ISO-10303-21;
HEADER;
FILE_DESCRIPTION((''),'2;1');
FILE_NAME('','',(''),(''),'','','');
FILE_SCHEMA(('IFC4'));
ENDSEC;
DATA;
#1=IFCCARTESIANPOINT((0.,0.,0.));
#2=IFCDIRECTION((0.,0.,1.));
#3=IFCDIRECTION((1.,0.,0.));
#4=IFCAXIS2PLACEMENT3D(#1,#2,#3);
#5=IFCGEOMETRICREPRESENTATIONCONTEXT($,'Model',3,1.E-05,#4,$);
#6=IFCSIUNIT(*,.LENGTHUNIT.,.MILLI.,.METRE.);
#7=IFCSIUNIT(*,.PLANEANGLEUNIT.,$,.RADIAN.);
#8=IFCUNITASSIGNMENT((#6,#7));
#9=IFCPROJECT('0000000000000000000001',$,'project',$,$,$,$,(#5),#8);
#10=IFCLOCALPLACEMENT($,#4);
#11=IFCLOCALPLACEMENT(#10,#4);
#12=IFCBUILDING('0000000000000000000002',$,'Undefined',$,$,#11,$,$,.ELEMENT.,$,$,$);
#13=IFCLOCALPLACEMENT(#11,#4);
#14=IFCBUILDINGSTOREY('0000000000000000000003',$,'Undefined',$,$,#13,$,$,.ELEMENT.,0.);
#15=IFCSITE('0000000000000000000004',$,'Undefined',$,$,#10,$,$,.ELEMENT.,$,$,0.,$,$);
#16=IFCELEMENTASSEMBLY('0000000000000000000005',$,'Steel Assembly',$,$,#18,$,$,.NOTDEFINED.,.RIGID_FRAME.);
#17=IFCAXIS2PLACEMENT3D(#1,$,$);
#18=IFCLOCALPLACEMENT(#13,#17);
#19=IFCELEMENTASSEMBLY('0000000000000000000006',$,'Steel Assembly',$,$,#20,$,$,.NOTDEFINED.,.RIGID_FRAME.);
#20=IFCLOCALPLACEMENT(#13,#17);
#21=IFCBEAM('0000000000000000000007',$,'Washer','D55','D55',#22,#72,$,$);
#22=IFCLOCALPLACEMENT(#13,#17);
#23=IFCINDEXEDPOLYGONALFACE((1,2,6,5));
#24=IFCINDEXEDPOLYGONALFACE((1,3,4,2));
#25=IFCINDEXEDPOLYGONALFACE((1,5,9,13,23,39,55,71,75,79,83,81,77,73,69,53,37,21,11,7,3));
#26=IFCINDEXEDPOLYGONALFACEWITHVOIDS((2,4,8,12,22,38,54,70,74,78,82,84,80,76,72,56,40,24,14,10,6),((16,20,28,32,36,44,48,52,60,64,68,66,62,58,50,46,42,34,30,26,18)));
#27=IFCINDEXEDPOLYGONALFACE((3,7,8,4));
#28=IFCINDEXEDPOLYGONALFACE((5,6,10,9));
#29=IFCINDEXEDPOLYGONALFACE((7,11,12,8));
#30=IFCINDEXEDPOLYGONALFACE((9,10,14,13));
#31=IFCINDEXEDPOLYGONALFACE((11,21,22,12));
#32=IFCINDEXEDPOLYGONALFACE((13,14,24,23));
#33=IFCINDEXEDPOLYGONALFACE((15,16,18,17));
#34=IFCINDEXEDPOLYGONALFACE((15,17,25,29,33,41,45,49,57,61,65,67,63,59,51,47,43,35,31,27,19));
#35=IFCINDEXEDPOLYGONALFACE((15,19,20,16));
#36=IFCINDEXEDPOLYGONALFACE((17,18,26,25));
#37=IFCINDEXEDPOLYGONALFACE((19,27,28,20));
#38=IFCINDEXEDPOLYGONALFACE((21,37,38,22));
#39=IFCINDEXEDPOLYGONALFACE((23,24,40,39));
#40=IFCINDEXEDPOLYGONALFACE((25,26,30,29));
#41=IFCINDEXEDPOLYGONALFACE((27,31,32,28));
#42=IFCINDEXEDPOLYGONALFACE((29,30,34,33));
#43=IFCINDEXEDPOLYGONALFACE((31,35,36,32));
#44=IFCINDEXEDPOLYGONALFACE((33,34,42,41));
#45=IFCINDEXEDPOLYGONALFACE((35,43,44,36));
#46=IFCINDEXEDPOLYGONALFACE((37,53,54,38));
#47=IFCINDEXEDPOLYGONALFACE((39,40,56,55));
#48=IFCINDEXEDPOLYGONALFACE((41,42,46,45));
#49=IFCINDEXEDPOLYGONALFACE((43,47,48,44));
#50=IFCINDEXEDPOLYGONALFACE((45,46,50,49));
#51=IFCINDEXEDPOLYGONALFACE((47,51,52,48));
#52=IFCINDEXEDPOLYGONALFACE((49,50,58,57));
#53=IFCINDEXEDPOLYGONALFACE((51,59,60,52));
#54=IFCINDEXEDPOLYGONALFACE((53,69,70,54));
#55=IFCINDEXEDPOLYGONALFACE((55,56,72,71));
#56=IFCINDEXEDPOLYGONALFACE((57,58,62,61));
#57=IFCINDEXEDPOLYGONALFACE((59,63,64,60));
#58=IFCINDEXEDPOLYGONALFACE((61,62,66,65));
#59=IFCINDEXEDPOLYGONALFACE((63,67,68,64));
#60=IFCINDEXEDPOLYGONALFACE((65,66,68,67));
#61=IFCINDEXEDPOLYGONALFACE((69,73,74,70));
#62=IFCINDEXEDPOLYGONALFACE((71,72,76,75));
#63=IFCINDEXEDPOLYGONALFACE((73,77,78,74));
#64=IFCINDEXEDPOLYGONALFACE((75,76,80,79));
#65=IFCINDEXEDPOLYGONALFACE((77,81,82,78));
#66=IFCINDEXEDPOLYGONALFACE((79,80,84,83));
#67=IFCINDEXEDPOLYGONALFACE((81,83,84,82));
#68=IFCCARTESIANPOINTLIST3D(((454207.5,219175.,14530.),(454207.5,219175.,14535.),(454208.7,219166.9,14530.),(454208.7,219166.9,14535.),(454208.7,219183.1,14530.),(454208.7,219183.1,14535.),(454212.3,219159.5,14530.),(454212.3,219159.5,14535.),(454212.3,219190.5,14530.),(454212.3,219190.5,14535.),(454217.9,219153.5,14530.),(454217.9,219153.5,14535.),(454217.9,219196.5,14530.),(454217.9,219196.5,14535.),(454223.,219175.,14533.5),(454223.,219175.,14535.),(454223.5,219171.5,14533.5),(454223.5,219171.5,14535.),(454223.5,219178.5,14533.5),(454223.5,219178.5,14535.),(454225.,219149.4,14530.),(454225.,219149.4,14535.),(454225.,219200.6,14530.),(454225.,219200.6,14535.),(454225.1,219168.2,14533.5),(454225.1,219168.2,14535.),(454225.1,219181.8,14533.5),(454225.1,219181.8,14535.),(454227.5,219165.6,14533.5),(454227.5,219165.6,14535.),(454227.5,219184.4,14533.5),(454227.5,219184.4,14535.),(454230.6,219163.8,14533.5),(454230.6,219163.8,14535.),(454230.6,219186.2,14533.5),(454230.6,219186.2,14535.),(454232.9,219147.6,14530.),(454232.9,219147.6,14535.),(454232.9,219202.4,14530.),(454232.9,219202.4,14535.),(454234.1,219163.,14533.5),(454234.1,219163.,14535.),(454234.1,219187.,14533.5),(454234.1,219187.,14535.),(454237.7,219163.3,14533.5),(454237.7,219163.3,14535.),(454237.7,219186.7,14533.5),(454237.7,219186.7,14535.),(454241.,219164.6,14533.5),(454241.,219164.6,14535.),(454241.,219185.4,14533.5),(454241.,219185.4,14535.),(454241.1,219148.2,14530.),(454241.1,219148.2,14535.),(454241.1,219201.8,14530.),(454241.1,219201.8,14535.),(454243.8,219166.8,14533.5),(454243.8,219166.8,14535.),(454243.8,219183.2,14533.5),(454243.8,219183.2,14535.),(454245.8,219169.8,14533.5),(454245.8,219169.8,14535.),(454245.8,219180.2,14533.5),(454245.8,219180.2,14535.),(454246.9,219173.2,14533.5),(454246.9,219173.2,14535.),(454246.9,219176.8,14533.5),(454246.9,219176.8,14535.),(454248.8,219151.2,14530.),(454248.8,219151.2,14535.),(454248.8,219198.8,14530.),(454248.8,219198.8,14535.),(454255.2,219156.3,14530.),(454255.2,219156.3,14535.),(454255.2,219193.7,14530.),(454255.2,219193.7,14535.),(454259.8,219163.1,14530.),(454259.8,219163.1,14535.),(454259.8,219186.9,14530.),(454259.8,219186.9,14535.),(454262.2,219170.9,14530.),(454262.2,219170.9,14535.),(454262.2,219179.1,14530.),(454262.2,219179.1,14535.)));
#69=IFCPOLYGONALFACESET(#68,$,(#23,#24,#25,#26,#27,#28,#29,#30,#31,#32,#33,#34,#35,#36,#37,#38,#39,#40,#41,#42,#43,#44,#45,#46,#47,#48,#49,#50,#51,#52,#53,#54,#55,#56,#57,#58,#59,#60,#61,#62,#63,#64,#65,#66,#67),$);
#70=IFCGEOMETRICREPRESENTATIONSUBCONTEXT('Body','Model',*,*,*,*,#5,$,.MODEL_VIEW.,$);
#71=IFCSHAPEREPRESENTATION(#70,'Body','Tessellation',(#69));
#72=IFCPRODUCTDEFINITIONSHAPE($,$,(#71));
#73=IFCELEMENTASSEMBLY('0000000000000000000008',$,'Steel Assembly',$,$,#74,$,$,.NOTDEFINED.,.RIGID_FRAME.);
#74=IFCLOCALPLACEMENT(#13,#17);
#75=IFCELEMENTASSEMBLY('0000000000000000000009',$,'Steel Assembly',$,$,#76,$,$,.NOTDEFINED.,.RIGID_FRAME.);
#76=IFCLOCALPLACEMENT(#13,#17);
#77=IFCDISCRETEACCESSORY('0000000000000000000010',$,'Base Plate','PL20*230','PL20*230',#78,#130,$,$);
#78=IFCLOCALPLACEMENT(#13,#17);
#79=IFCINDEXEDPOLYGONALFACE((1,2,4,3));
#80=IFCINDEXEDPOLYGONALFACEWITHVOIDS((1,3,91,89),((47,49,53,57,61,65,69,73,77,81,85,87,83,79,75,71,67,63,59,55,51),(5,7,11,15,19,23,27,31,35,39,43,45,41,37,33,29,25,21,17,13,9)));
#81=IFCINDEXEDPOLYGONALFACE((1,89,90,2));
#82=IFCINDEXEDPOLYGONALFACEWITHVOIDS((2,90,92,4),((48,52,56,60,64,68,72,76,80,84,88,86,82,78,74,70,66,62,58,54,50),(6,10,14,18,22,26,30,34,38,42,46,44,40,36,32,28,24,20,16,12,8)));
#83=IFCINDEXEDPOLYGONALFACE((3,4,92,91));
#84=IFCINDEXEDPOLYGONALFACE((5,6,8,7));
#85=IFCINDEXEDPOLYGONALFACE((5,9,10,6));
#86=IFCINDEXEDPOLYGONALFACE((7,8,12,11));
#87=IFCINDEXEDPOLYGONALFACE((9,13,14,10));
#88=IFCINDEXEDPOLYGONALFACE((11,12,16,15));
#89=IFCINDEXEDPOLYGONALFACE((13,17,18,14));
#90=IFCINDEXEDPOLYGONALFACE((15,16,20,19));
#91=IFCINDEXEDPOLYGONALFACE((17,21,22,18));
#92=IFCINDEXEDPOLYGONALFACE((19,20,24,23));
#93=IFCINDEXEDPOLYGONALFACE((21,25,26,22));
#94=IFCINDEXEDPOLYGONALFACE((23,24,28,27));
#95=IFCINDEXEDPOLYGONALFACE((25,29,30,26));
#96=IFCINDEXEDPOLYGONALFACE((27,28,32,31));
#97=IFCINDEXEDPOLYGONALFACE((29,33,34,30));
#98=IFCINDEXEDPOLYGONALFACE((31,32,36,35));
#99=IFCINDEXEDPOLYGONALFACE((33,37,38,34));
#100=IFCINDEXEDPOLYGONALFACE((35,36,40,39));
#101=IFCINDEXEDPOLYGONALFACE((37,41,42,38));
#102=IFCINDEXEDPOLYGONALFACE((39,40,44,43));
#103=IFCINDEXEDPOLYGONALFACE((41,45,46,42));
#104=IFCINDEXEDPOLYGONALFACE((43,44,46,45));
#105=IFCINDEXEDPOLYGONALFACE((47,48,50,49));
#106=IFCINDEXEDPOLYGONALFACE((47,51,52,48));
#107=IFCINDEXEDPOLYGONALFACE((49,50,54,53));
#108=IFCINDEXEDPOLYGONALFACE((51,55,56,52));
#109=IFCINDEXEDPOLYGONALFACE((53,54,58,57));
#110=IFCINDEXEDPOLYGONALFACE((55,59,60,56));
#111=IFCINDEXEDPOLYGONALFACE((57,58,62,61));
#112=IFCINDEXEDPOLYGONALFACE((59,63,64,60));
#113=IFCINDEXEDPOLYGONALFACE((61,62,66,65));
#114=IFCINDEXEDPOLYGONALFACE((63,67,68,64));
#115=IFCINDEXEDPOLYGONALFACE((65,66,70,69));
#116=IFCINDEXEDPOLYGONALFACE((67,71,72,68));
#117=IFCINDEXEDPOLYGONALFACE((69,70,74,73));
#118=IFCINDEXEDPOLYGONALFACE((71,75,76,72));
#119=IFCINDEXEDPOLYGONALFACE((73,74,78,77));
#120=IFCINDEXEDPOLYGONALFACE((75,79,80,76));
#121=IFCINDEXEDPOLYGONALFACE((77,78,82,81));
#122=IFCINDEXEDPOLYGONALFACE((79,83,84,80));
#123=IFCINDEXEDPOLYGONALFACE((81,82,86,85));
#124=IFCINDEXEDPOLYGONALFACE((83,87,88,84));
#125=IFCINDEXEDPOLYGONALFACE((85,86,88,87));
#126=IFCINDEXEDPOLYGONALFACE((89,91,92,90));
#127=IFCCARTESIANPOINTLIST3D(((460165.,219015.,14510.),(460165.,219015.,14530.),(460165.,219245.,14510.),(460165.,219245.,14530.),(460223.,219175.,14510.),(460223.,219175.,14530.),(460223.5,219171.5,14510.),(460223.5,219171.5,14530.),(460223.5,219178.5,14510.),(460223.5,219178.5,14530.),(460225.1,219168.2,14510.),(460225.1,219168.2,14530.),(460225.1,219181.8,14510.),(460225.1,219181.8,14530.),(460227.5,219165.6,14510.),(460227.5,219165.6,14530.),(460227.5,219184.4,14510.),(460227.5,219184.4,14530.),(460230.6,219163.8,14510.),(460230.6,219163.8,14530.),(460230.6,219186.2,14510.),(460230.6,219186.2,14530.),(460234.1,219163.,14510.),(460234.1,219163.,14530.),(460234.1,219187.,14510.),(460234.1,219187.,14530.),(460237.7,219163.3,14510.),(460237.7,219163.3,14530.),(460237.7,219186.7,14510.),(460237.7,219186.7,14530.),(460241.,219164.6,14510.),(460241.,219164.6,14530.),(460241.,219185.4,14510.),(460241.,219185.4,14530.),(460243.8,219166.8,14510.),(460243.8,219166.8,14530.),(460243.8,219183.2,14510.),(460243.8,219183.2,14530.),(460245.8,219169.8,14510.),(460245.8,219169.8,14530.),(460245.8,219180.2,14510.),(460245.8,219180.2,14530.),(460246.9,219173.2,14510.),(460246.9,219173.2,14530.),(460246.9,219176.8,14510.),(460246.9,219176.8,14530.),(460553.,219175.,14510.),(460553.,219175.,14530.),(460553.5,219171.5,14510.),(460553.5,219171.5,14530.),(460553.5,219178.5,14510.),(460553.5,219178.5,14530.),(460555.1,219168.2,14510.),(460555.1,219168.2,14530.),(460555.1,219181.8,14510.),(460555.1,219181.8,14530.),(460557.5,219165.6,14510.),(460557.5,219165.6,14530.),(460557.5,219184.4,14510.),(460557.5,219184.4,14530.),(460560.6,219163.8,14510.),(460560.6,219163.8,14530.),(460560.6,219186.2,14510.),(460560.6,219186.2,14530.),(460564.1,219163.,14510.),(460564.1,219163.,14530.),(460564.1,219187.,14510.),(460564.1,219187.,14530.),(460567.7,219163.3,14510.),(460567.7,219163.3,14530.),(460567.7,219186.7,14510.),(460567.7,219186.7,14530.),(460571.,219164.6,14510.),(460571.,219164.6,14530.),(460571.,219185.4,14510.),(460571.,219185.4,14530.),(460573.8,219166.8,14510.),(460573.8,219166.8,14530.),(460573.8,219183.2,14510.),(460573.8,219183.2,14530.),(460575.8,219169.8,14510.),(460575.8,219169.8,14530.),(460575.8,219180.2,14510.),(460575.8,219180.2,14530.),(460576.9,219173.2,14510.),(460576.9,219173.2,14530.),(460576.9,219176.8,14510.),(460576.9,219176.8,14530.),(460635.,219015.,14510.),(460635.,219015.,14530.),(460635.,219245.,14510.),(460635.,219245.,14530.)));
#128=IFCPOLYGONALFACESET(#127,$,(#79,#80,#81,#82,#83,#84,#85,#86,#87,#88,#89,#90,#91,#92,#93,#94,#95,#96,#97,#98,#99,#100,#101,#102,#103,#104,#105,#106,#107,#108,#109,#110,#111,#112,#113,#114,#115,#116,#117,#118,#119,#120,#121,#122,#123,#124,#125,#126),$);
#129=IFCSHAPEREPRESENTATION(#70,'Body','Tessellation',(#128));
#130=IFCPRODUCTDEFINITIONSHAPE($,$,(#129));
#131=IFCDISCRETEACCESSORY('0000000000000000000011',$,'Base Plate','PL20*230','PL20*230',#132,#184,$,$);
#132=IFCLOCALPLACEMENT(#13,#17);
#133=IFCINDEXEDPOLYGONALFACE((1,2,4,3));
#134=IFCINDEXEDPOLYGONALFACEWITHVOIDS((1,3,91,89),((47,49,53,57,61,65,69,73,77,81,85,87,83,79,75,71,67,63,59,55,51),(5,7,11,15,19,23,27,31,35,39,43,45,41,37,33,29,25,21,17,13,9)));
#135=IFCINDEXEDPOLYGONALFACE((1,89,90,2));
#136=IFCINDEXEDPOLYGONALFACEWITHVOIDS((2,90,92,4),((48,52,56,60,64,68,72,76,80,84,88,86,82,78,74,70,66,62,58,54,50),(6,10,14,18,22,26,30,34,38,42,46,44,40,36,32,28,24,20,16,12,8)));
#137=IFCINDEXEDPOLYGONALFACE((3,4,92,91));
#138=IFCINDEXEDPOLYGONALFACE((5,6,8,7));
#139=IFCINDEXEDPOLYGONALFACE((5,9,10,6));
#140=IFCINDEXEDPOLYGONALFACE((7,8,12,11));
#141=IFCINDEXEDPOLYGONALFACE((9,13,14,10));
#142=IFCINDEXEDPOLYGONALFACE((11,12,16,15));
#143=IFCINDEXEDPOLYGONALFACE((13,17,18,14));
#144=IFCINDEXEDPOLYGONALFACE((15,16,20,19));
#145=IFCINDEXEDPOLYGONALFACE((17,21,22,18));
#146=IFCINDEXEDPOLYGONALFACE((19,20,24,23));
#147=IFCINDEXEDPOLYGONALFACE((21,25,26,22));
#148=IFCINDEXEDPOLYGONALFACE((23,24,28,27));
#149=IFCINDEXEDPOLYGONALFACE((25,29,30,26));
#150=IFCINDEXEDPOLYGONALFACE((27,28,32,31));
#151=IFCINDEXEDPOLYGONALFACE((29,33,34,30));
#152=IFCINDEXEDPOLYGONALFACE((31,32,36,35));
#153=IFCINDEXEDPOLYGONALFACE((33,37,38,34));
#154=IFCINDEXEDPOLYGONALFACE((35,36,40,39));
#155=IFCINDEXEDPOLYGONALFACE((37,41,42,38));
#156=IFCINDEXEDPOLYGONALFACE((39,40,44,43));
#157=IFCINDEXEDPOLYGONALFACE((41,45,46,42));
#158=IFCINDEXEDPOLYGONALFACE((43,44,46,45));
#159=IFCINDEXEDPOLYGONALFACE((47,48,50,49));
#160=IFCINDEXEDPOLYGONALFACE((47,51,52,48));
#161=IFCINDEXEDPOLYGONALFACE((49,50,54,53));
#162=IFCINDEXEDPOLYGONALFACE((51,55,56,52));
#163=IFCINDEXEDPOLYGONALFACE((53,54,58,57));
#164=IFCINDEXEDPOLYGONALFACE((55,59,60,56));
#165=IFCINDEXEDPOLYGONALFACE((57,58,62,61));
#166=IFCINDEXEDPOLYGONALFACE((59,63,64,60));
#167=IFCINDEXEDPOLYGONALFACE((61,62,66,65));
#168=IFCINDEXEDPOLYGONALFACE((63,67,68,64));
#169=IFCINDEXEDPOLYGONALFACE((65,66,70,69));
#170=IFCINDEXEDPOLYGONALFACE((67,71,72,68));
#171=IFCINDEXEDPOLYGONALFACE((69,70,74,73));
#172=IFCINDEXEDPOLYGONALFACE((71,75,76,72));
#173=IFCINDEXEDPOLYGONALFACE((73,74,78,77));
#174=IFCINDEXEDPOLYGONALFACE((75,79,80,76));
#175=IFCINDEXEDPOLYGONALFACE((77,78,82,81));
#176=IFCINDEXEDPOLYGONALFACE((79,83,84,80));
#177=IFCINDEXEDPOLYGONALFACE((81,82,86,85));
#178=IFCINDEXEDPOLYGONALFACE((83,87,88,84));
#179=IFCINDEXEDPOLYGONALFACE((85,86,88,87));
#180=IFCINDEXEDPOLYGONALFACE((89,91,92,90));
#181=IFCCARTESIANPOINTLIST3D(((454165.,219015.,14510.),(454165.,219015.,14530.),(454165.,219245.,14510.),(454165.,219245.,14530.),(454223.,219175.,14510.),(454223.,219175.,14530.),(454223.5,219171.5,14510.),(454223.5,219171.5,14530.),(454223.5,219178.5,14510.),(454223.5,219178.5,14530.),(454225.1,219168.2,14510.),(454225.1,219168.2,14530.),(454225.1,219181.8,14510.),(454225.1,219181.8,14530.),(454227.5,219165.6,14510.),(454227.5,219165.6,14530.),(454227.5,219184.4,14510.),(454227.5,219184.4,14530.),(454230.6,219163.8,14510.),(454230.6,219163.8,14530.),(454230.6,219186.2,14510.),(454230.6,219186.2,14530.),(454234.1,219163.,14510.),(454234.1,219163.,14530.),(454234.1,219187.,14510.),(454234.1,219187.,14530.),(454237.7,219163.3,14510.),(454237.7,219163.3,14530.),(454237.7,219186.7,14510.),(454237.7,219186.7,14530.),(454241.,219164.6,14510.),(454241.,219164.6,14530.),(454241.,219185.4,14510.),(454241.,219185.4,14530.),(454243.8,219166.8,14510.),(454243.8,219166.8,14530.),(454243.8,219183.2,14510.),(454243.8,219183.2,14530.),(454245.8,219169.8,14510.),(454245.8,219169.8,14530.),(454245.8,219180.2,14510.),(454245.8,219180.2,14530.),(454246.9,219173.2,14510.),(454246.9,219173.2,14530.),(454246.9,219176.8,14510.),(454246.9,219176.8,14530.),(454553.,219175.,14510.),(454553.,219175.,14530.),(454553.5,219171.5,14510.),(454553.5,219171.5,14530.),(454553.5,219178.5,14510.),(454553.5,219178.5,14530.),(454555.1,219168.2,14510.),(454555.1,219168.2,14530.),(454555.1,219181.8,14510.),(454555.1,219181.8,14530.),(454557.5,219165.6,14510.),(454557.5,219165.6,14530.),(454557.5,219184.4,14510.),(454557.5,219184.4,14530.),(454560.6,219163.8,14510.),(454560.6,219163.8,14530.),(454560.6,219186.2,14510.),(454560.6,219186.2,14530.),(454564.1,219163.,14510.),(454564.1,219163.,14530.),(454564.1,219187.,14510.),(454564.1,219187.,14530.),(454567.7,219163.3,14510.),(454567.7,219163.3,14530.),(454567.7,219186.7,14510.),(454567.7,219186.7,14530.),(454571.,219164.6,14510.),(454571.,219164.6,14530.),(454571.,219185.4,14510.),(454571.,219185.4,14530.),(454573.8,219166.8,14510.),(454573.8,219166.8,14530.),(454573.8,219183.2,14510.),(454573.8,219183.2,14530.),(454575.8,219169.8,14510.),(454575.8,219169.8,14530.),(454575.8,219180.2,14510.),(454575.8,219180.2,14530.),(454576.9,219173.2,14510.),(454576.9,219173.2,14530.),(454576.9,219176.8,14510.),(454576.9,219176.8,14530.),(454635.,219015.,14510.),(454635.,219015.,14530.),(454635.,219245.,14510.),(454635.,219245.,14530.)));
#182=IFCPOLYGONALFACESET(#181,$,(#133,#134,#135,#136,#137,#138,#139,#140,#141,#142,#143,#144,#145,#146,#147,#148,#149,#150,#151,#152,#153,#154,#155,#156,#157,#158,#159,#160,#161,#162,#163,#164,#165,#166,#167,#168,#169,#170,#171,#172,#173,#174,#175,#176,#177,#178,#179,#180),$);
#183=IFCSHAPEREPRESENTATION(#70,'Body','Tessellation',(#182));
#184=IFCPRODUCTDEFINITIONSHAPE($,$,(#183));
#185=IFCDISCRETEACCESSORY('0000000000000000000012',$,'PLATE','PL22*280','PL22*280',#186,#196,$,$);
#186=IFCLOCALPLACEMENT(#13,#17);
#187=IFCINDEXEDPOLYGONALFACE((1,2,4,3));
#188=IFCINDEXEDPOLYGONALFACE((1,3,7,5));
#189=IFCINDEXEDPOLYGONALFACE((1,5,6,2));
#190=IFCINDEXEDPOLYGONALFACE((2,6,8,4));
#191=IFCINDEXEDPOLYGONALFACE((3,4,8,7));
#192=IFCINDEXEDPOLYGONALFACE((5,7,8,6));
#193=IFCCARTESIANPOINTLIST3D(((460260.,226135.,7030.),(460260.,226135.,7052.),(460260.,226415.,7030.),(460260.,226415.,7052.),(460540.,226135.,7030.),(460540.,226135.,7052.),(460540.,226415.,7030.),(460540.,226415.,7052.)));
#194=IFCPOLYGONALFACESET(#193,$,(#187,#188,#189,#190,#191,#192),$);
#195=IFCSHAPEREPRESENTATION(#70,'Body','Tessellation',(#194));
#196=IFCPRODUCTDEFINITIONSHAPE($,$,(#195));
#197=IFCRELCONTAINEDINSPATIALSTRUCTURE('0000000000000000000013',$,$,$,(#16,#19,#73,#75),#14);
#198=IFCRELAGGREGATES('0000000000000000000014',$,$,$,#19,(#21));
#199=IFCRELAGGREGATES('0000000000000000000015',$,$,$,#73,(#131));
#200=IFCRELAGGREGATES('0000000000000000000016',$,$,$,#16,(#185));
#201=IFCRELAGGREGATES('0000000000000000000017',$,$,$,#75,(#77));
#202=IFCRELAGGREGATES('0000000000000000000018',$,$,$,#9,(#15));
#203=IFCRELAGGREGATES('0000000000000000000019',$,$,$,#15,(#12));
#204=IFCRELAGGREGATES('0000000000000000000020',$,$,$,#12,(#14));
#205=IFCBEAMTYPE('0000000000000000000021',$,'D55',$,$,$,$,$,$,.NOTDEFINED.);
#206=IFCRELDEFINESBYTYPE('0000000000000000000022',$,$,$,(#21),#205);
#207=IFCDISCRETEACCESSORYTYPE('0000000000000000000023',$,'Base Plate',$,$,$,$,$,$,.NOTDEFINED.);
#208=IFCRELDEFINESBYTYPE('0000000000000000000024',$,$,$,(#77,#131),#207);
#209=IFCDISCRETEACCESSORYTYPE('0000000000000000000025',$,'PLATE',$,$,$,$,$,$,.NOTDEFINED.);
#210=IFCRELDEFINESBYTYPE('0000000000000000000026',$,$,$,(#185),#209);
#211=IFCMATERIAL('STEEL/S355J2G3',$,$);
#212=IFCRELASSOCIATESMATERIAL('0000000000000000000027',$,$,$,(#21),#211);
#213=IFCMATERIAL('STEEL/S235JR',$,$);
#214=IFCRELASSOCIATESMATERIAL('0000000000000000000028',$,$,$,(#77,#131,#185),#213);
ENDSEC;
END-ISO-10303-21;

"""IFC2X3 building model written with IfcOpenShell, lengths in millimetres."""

from ifc_helpers import new_model, si_unit, frame, origin_with_axes, origin_2d_with_axis, place, context, subcontext, project, spatial, polyline, circle, outline, extrude, boolean, material, type_object, element, aggregate, save


model = new_model("IFC2X3")

# Units and contexts
model_context = context("Model", 3, precision=1e-05, world=origin_with_axes())
body_context = subcontext(model_context, "Body", "Model", "MODEL_VIEW")
ifc_project = project(units=[si_unit("LENGTHUNIT", "METRE", prefix="MILLI"), si_unit("PLANEANGLEUNIT", "RADIAN")], contexts=[model_context])

# Site, building, storey
site_placement = place(None, origin_with_axes())
site = spatial("IfcSite", under=ifc_project, at=site_placement, Name="Undefined", CompositionType="ELEMENT", RefElevation=0.0)
building_placement = place(site_placement, origin_with_axes())
building = spatial("IfcBuilding", under=site, at=building_placement, Name="Undefined", CompositionType="ELEMENT")
storey_placement = place(building_placement, origin_with_axes())
storey = spatial("IfcBuildingStorey", under=building, at=storey_placement, Name="Undefined", CompositionType="ELEMENT", Elevation=0.0)

# Element assembly
ifc_material_1 = material(Name="STEEL/S235JR")
assembly_1_placement = place(storey_placement, origin_with_axes())
assembly_1 = element("IfcElementAssembly", 1, at=assembly_1_placement, inside=storey, Name="Steel Assembly", AssemblyPlace="NOTDEFINED", PredefinedType="RIGID_FRAME")

# Element assembly, beam
ifc_material_2 = material(Name="STEEL/S355J2G3")
beam_type = type_object("IfcBeamType", Name="D55", PredefinedType="NOTDEFINED")
assembly_2_placement = place(storey_placement, origin_with_axes())
assembly_2 = element("IfcElementAssembly", 2, at=assembly_2_placement, inside=storey, Name="Steel Assembly", AssemblyPlace="NOTDEFINED", PredefinedType="RIGID_FRAME")
beam_1_placement = place(assembly_2_placement, frame((454235.0, 219175.0, 14535.0), z_axis=(0.0, -1.0, 0.0), x_axis=(0.0, 0.0, -1.0)))
beam_1 = element("IfcBeam", 3, at=beam_1_placement, type_object=beam_type, material=ifc_material_2, Name="Washer", Description="D55", ObjectType="D55", context=body_context, shape_type="CSG", body=[
    boolean("DIFFERENCE", extrude(circle(Radius=27.5, at=origin_2d_with_axis()), frame((5.0, 0.0, 0.0), z_axis=(-1.0, 0.0, 0.0), x_axis=(0.0, -1.0, 0.0)), (0.0, 0.0, 1.0), 5.0), extrude(circle(Radius=12.0, at=origin_2d_with_axis()), frame((1.5, 0.0, 0.0), z_axis=(-1.0, 0.0, 0.0), x_axis=(0.0, -1.0, 0.0)), (0.0, 0.0, 1.0), 10.0)),
])
aggregate(assembly_2, [beam_1])

# Element assembly
assembly_3_placement = place(storey_placement, origin_with_axes())
assembly_3 = element("IfcElementAssembly", 4, at=assembly_3_placement, inside=storey, Name="Steel Assembly", AssemblyPlace="NOTDEFINED", PredefinedType="RIGID_FRAME")

# Element assembly
assembly_4_placement = place(storey_placement, origin_with_axes())
assembly_4 = element("IfcElementAssembly", 5, at=assembly_4_placement, inside=storey, Name="Steel Assembly", AssemblyPlace="NOTDEFINED", PredefinedType="RIGID_FRAME")

# Discrete accessories
discrete_accessory_type_1 = type_object("IfcDiscreteAccessoryType", Name="Base Plate")
discrete_accessory_1_placement = place(assembly_4_placement, frame((460165.0, 219245.0, 14520.0), z_axis=(0.0, 0.0, -1.0), x_axis=(1.0, 0.0, 0.0)))
discrete_accessory_1 = element("IfcDiscreteAccessory", 6, at=discrete_accessory_1_placement, type_object=discrete_accessory_type_1, material=ifc_material_1, Name="Base Plate", Description="PL20*230", ObjectType="PL20*230", context=body_context, shape_type="CSG", body=[
    boolean("DIFFERENCE", boolean("DIFFERENCE", extrude(outline(polyline([(0.0, 0.0), (470.0, 0.0), (470.0, 230.0), (0.0, 230.0), (0.0, 0.0)])), frame((0.0, 0.0, -10.0), z_axis=(0.0, 0.0, 1.0), x_axis=(1.0, 0.0, 0.0)), (0.0, 0.0, 1.0), 20.0), extrude(circle(Radius=12.0, at=origin_2d_with_axis()), frame((70.0, 70.0, -80.0), z_axis=(0.0, 0.0, 1.0), x_axis=(-1.0, 0.0, 0.0)), (0.0, 0.0, 1.0), 1160.0)), extrude(circle(Radius=12.0, at=origin_2d_with_axis()), frame((400.0, 70.0, -80.0), z_axis=(0.0, 0.0, 1.0), x_axis=(-1.0, 0.0, 0.0)), (0.0, 0.0, 1.0), 1160.0)),
])
discrete_accessory_2_placement = place(assembly_3_placement, frame((454165.0, 219245.0, 14520.0), z_axis=(0.0, 0.0, -1.0), x_axis=(1.0, 0.0, 0.0)))
discrete_accessory_2 = element("IfcDiscreteAccessory", 7, at=discrete_accessory_2_placement, type_object=discrete_accessory_type_1, material=ifc_material_1, Name="Base Plate", Description="PL20*230", ObjectType="PL20*230", context=body_context, shape_type="CSG", body=[
    boolean("DIFFERENCE", boolean("DIFFERENCE", extrude(outline(polyline([(0.0, 0.0), (470.0, 0.0), (470.0, 230.0), (0.0, 230.0), (0.0, 0.0)])), frame((0.0, 0.0, -10.0), z_axis=(0.0, 0.0, 1.0), x_axis=(1.0, 0.0, 0.0)), (0.0, 0.0, 1.0), 20.0), extrude(circle(Radius=12.0, at=origin_2d_with_axis()), frame((70.0, 70.0, -80.0), z_axis=(0.0, 0.0, 1.0), x_axis=(-1.0, 0.0, 0.0)), (0.0, 0.0, 1.0), 1160.0)), extrude(circle(Radius=12.0, at=origin_2d_with_axis()), frame((400.0, 70.0, -80.0), z_axis=(0.0, 0.0, 1.0), x_axis=(-1.0, 0.0, 0.0)), (0.0, 0.0, 1.0), 1160.0)),
])
aggregate(assembly_3, [discrete_accessory_2])
discrete_accessory_type_2 = type_object("IfcDiscreteAccessoryType", Name="PLATE")
discrete_accessory_3_placement = place(assembly_1_placement, frame((460400.0, 226135.0, 7041.0), z_axis=(0.0, 0.0, 1.0), x_axis=(0.0, 1.0, 0.0)))
discrete_accessory_3 = element("IfcDiscreteAccessory", 8, at=discrete_accessory_3_placement, type_object=discrete_accessory_type_2, material=ifc_material_1, Name="PLATE", Description="PL22*280", ObjectType="PL22*280", context=body_context, shape_type="SweptSolid", body=[
    extrude(outline(polyline([(280.0, 140.0), (280.0, -140.0), (0.0, -140.0), (0.0, 140.0), (280.0, 140.0)])), frame((0.0, 0.0, -11.0), z_axis=(0.0, 0.0, 1.0), x_axis=(1.0, 0.0, 0.0)), (0.0, 0.0, 1.0), 22.0),
])
aggregate(assembly_1, [discrete_accessory_3])
aggregate(assembly_4, [discrete_accessory_1])

save(model, "model.ifc")
